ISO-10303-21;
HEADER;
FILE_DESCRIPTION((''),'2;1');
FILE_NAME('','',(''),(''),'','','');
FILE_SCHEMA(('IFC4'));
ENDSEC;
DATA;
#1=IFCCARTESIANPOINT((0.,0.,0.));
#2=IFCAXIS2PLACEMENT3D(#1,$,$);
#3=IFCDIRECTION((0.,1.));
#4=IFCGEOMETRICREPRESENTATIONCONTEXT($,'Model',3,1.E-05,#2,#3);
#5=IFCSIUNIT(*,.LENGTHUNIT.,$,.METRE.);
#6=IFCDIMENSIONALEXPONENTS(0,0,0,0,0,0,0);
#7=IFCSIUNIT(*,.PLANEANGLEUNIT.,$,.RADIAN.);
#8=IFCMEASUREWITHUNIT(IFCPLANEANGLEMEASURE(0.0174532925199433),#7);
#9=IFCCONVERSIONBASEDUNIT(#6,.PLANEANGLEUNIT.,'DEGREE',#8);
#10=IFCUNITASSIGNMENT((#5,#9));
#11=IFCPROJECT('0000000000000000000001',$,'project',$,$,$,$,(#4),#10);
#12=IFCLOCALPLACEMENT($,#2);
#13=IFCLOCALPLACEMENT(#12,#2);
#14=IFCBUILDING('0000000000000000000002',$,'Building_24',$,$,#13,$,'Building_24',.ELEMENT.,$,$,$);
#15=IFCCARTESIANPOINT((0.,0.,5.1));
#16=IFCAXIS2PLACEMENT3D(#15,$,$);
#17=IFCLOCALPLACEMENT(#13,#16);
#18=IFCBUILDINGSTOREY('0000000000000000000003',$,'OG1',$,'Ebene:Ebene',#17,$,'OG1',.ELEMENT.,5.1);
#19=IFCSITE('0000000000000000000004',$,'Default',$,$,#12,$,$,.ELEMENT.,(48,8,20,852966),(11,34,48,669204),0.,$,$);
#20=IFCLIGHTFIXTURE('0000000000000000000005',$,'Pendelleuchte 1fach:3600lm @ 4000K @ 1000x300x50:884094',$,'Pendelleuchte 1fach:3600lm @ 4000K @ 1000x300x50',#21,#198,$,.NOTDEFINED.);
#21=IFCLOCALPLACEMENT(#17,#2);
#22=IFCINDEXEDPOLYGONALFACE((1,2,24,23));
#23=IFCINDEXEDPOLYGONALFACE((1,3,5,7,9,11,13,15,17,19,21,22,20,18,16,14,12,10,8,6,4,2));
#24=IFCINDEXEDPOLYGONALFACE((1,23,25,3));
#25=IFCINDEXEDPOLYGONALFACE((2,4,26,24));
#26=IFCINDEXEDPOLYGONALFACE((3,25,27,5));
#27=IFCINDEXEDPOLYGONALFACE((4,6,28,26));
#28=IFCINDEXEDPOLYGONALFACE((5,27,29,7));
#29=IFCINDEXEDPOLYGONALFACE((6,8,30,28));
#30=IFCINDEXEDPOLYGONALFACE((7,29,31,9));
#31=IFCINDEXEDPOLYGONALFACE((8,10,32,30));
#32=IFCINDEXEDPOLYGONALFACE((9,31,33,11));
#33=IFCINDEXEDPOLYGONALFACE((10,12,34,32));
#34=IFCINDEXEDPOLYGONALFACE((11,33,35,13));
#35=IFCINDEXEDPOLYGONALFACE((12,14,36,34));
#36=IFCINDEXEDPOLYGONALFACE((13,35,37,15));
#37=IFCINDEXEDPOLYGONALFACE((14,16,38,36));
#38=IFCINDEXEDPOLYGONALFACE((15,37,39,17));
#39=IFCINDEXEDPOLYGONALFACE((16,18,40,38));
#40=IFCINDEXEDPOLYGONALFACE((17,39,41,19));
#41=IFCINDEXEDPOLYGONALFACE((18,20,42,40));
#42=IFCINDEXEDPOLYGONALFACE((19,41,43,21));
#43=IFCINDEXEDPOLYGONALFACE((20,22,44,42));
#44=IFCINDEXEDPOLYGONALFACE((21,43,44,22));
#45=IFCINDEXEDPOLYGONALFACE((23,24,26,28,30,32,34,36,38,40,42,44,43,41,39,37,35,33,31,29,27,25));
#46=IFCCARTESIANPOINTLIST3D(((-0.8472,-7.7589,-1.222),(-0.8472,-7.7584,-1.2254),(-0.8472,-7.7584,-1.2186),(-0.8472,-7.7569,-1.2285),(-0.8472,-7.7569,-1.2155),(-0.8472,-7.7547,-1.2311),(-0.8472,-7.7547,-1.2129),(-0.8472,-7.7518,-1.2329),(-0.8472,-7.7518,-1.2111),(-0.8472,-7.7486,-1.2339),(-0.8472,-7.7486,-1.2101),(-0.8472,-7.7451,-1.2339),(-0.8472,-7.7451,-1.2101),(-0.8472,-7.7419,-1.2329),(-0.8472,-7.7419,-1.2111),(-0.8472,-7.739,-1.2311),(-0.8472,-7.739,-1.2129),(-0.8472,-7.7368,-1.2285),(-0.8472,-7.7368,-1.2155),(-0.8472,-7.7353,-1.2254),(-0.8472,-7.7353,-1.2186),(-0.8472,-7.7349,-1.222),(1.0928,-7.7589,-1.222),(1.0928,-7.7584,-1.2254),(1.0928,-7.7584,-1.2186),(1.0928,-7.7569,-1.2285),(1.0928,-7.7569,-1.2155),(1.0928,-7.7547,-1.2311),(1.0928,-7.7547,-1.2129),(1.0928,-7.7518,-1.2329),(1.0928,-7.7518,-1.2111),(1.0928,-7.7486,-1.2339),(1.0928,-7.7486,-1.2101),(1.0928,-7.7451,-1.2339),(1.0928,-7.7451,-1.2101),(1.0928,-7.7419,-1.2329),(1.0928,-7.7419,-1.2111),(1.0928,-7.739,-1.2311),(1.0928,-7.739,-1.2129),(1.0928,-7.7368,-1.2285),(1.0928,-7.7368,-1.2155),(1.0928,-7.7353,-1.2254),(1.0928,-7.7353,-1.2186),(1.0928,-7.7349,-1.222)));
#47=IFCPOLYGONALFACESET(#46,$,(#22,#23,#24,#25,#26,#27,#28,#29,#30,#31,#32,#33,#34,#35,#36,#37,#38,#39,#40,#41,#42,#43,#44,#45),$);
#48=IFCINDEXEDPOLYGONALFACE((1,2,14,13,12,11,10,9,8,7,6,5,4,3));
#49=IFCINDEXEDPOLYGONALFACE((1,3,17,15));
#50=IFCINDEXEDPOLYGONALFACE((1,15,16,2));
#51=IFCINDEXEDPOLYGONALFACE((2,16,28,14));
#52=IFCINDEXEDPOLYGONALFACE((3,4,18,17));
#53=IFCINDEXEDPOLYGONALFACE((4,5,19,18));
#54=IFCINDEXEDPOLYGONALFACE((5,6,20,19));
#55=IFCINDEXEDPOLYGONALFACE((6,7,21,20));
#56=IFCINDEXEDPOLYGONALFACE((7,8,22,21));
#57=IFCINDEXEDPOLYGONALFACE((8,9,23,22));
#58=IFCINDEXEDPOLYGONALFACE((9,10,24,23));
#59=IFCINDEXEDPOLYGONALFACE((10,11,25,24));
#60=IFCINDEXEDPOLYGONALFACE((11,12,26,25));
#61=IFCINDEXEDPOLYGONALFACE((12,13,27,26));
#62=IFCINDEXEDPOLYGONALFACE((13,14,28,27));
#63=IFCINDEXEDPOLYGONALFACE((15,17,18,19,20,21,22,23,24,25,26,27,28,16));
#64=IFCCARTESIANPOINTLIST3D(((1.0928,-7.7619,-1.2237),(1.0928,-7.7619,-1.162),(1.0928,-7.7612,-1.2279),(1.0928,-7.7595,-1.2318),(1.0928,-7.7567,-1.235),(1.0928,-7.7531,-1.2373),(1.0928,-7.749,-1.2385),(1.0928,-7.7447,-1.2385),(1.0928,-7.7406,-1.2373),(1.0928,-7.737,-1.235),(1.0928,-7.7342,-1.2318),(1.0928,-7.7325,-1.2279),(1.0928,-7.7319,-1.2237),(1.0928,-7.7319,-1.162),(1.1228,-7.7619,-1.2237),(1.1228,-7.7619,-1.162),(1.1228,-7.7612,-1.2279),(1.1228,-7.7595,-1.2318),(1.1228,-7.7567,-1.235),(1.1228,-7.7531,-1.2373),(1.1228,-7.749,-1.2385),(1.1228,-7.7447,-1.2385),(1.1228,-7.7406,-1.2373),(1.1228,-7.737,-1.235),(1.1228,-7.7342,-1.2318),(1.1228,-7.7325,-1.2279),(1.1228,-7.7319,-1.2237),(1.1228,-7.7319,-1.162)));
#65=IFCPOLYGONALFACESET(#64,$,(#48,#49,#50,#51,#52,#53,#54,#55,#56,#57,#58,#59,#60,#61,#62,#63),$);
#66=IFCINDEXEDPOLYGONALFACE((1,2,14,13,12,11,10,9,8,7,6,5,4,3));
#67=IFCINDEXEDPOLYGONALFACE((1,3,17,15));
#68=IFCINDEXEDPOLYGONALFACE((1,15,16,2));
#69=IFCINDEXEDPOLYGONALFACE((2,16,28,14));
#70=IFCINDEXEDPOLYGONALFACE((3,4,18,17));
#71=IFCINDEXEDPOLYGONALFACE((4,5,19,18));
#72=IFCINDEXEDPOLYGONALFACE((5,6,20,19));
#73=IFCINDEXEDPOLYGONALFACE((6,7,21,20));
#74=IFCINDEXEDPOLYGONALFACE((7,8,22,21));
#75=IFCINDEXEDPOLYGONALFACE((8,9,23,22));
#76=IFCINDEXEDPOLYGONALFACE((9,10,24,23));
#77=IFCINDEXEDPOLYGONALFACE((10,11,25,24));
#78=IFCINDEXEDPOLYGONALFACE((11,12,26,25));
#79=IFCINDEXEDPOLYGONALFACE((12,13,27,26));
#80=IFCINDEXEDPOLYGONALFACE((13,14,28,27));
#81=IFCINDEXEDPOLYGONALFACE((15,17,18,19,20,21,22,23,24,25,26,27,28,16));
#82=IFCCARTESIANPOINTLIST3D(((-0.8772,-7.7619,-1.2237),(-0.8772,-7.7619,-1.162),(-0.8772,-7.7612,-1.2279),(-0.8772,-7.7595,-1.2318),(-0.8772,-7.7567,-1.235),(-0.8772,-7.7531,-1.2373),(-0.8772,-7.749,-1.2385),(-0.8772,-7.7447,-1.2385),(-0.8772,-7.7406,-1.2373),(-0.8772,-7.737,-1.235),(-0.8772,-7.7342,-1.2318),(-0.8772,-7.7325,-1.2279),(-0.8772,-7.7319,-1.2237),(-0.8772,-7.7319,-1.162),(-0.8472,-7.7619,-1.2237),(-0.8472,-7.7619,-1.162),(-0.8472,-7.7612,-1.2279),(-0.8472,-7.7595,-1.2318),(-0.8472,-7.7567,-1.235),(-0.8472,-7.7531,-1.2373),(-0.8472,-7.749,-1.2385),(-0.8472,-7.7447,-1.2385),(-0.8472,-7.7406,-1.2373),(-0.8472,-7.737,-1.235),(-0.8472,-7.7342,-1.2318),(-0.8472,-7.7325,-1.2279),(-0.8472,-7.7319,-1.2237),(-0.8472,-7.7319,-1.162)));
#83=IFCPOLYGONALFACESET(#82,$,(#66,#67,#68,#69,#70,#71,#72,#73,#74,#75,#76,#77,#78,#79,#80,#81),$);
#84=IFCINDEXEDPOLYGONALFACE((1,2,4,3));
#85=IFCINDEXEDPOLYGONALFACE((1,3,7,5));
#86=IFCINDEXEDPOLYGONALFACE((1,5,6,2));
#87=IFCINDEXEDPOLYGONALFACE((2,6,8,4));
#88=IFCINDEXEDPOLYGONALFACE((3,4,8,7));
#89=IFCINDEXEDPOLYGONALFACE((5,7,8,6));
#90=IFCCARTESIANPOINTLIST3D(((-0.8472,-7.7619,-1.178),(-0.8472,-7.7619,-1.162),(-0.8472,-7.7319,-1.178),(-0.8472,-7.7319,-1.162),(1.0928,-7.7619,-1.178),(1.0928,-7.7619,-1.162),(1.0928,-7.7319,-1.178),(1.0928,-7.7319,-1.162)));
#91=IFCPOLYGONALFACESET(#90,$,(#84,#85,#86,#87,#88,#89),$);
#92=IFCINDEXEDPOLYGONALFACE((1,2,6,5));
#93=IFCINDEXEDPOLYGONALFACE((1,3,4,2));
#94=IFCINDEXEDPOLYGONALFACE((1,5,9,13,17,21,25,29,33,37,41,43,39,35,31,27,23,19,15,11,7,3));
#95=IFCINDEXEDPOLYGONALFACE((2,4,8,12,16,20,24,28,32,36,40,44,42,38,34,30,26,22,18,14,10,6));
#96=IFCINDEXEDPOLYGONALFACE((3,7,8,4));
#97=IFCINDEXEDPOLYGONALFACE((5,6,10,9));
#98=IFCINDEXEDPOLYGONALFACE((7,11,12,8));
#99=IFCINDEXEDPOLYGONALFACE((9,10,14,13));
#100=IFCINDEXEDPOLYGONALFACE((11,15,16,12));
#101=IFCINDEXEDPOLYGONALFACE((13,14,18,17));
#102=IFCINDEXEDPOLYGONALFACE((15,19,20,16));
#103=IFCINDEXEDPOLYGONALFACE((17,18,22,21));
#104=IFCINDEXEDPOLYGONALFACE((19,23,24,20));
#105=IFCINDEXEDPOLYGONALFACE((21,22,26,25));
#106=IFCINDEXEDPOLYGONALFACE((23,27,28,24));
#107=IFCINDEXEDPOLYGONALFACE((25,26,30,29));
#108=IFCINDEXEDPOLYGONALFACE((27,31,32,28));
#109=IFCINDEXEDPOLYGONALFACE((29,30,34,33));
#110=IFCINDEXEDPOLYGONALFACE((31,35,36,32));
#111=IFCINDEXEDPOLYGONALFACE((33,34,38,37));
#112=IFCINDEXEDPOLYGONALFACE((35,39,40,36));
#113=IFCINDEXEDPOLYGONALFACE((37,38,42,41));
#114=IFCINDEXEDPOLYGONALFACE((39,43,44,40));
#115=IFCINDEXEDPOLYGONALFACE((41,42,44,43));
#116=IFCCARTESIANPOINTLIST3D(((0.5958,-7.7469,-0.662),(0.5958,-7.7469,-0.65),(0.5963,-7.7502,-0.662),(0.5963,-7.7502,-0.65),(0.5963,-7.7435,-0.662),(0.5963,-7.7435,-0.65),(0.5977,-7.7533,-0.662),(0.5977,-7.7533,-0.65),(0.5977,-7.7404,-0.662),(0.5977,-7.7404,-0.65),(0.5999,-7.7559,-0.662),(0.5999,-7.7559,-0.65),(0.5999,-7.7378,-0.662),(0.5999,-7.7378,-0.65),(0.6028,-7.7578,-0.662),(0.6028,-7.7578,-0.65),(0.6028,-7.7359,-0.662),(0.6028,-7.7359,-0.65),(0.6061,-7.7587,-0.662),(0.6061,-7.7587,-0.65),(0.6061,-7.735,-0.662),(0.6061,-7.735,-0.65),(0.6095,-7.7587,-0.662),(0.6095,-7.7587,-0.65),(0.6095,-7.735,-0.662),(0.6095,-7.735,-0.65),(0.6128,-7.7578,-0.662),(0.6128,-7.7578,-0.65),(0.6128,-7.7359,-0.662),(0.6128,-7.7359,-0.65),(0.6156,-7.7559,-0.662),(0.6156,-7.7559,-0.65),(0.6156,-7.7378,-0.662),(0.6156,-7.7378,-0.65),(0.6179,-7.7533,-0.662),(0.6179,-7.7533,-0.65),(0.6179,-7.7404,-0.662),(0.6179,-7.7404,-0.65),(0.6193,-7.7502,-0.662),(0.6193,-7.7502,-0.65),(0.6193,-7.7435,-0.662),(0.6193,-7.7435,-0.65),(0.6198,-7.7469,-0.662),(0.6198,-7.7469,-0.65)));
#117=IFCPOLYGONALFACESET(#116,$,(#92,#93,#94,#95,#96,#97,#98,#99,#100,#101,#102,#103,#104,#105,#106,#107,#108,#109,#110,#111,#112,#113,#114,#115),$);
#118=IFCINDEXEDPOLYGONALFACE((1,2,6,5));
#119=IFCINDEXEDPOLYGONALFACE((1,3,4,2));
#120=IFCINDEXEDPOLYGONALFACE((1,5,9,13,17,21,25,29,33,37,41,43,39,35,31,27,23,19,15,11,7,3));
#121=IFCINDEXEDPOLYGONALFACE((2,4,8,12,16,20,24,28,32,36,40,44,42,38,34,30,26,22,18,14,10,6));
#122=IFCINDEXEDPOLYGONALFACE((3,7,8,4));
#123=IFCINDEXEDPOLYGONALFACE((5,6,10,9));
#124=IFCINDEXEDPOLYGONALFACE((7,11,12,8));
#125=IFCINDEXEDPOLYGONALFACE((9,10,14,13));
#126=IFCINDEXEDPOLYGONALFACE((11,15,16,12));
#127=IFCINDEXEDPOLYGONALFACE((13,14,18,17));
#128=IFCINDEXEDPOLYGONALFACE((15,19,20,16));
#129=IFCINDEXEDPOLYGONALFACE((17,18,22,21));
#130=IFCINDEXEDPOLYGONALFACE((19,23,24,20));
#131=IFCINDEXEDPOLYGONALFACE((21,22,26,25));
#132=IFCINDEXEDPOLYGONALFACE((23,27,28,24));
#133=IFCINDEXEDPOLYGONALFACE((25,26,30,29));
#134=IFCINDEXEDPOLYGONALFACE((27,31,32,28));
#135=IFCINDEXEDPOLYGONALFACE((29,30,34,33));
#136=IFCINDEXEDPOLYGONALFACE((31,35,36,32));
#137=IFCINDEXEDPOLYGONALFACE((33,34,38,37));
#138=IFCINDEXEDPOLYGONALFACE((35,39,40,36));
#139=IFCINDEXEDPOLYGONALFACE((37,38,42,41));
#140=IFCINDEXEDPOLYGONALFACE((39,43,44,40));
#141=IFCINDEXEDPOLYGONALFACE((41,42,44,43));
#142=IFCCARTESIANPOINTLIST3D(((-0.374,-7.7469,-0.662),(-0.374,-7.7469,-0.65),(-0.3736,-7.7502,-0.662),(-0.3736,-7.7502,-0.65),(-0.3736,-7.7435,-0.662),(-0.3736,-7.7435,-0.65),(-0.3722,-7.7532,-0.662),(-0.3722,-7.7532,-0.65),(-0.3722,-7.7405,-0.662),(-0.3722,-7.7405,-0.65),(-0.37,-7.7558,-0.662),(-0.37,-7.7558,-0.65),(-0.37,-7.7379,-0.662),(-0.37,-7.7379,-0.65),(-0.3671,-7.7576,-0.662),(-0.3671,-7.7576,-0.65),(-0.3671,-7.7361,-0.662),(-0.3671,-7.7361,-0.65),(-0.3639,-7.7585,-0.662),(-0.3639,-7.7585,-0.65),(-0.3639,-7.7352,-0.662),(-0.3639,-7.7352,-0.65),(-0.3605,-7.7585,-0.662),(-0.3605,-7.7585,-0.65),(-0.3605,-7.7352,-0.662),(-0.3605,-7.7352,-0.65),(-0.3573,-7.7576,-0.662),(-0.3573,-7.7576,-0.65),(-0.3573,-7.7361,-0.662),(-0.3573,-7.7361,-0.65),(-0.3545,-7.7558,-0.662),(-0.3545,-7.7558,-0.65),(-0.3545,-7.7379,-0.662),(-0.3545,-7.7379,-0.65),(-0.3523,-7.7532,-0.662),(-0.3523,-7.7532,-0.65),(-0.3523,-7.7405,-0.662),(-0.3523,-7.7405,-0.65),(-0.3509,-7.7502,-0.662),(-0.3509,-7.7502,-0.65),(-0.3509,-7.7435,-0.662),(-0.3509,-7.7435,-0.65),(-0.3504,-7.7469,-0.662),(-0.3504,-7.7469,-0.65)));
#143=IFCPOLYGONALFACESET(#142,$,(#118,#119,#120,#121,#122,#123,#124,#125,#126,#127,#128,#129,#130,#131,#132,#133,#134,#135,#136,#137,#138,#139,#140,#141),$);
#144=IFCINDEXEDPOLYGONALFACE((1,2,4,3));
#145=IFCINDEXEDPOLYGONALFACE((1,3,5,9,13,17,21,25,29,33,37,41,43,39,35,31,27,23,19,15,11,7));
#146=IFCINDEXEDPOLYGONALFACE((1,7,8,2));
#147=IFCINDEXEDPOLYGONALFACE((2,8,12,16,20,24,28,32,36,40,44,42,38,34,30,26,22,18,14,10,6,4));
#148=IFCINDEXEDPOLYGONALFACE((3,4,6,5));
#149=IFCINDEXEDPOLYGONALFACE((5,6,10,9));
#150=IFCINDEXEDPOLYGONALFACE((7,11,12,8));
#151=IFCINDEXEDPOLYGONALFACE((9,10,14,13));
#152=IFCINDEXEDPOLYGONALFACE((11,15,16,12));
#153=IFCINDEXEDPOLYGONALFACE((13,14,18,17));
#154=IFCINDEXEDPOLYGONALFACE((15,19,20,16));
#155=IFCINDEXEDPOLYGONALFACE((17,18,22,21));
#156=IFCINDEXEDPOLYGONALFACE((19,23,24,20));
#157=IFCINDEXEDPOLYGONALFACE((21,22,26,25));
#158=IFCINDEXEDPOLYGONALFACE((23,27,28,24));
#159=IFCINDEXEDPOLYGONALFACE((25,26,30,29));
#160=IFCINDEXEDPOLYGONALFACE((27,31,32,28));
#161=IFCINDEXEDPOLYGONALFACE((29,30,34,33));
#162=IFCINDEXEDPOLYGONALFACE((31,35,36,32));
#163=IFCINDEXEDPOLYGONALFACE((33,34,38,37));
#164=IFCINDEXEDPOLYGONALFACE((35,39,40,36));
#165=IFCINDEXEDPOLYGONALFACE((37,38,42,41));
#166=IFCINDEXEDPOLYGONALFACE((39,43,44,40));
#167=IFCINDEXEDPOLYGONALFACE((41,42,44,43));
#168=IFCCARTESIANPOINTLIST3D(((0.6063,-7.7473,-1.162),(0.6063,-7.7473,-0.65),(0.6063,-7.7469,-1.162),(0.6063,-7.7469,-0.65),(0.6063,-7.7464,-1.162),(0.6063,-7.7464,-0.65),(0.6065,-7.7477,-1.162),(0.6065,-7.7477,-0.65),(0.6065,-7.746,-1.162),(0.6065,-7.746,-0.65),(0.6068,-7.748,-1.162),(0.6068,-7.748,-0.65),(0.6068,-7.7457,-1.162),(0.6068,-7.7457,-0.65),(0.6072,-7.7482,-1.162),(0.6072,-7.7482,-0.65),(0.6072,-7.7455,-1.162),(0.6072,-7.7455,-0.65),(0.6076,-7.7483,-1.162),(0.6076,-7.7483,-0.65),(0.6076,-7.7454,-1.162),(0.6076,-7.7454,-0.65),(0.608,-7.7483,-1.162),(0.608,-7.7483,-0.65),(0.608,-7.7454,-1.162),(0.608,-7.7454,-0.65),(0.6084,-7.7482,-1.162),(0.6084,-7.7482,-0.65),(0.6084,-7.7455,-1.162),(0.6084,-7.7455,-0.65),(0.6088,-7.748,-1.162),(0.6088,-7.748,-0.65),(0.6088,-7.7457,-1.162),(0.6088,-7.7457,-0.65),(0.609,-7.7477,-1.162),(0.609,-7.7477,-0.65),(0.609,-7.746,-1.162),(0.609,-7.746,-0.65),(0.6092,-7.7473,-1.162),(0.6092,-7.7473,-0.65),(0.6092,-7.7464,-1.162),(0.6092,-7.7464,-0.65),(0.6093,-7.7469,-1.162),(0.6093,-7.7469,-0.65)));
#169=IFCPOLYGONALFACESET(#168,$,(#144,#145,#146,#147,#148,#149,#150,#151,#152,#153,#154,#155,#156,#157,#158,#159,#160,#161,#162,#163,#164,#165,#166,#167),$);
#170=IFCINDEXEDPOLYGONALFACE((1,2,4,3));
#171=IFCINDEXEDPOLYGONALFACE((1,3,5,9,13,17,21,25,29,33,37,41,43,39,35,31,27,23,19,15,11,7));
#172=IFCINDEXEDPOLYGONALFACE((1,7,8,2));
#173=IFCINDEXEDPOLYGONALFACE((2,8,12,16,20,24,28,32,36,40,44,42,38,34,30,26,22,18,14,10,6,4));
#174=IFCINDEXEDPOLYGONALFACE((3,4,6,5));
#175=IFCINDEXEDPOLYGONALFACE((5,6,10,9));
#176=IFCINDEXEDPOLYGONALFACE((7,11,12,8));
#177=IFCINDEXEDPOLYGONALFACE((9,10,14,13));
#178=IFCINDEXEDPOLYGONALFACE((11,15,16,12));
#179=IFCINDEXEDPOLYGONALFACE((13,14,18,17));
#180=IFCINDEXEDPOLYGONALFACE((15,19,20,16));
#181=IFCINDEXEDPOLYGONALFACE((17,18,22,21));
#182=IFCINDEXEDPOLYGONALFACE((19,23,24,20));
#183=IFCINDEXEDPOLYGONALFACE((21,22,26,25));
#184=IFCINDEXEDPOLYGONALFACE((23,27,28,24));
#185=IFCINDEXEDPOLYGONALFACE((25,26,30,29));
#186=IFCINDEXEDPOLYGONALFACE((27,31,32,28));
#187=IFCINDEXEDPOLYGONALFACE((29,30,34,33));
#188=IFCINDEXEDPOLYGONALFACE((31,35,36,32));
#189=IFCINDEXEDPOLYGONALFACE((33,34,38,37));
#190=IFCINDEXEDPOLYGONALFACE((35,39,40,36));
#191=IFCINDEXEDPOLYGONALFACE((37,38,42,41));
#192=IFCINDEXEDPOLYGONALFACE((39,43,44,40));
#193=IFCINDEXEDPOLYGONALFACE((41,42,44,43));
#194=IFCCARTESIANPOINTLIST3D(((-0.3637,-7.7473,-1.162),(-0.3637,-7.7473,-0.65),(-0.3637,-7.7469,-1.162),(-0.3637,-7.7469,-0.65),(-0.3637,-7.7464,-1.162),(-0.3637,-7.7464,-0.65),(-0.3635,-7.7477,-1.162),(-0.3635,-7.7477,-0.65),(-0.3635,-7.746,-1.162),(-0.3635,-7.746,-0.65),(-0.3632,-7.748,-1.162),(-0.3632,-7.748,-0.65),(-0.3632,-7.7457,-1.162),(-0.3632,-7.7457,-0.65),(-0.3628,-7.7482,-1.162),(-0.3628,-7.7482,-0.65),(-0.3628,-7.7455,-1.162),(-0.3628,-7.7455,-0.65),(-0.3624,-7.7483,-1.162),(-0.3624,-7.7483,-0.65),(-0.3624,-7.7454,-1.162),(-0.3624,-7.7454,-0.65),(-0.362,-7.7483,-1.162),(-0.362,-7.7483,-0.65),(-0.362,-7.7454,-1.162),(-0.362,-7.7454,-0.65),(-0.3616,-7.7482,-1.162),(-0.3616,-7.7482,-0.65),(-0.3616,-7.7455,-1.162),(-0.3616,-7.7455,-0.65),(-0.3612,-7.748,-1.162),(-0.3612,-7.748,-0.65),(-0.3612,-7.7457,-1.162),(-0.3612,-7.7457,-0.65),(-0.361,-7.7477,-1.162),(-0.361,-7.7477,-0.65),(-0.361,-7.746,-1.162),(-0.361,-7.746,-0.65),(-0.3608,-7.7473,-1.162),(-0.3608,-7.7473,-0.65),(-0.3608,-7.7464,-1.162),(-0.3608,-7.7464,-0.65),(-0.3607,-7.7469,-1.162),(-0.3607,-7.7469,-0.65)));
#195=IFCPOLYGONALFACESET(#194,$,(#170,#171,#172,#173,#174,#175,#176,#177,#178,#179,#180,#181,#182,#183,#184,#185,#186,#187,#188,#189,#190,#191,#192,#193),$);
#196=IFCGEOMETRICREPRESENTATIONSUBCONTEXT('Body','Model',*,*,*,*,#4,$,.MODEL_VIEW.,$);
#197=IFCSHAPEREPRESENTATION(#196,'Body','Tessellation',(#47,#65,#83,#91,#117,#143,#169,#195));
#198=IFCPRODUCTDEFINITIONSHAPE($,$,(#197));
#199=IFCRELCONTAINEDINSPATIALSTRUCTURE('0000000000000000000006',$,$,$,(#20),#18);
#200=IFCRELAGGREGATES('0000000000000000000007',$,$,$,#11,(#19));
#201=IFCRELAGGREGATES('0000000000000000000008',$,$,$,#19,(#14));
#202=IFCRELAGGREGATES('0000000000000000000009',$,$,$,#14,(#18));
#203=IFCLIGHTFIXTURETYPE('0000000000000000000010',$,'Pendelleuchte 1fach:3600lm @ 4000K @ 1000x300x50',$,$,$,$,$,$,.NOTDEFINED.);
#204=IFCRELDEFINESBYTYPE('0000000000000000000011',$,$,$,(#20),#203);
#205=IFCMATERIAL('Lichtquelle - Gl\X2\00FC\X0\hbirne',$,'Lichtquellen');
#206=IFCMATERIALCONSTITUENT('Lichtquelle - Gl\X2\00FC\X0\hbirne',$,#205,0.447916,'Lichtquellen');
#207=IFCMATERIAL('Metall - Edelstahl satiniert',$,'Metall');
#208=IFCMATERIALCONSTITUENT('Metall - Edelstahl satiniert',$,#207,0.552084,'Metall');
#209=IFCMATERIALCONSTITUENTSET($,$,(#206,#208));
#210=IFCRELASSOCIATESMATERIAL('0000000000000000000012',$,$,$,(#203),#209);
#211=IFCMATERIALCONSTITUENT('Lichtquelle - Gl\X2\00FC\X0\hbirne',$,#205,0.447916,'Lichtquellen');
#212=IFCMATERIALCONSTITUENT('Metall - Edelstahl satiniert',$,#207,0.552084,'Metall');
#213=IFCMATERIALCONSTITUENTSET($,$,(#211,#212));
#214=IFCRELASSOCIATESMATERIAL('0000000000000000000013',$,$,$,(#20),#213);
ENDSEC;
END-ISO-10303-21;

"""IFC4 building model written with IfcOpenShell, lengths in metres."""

from ifc_helpers import new_model, entity, si_unit, converted_unit, direction, frame, origin, place, context, subcontext, project, spatial, line, arc, indexed_curve, outline, extrude, source, transform, mapped, material, constituent, constituent_set, type_object, type_shapes, element, save


model = new_model("IFC4")

# Units and contexts
model_context = context("Model", 3, precision=1e-05, world=origin(), true_north=direction((0.0, 1.0)))
body_context = subcontext(model_context, "Body", "Model", "MODEL_VIEW")
ifc_project = project(units=[si_unit("LENGTHUNIT", "METRE"), converted_unit("PLANEANGLEUNIT", "DEGREE", entity("IfcPlaneAngleMeasure", 0.0174532925199433), si_unit("PLANEANGLEUNIT", "RADIAN"), dimensions=[0, 0, 0, 0, 0, 0, 0])], contexts=[model_context])

# Site, building, storey
site_placement = place(None, origin())
site = spatial("IfcSite", under=ifc_project, at=site_placement, Name="Default", CompositionType="ELEMENT", RefLatitude=(48, 8, 20, 852966), RefLongitude=(11, 34, 48, 669204), RefElevation=0.0)
building_placement = place(site_placement, origin())
building = spatial("IfcBuilding", under=site, at=building_placement, Name="Building_24", LongName="Building_24", CompositionType="ELEMENT")
storey_placement = place(building_placement, frame((0.0, 0.0, 5.1)))
storey = spatial("IfcBuildingStorey", under=building, at=storey_placement, Name="OG1", ObjectType="Ebene:Ebene", LongName="OG1", CompositionType="ELEMENT", Elevation=5.1)

# Light fixture
ifc_material_1 = material(Name="Lichtquelle - Glühbirne", Category="Lichtquellen")
ifc_material_2 = material(Name="Metall - Edelstahl satiniert", Category="Metall")
ifc_constituent_1 = constituent(ifc_material_1, Name="Lichtquelle - Glühbirne", Category="Lichtquellen", fraction=0.447916)
ifc_constituent_2 = constituent(ifc_material_2, Name="Metall - Edelstahl satiniert", Category="Metall", fraction=0.552084)
ifc_constituent_set_1 = constituent_set(constituents=[ifc_constituent_1, ifc_constituent_2])
light_fixture_type_1 = type_object("IfcLightFixtureType", Name="Pendelleuchte 1fach:3600lm @ 4000K @ 1000x300x50", PredefinedType="NOTDEFINED", material=ifc_constituent_set_1)
shared_shape_1 = source(origin(), body_context, "Body", "SweptSolid", [
    extrude(outline(indexed_curve([(-0.012, 0.0), (0.0, -0.012), (0.012, 0.0), (0.0, 0.012)], segments=[arc(1, 2, 3), arc(3, 4, 1)], self_intersect=False)), frame((-0.97, 0.0, -0.572), z_axis=(1.0, 0.0, 0.0), x_axis=(0.0, 1.0, 0.0)), (0.0, 0.0, 1.0), 1.94),
    extrude(outline(indexed_curve([(-0.0308, -0.015), (0.0308, -0.015), (0.0308, 0.015), (-0.0308, 0.015), (-0.0458, 0.0)], segments=[line(1, 2, 3, 4), arc(4, 5, 1)], self_intersect=False)), frame((0.97, 0.0, -0.5428), z_axis=(1.0, 0.0, 0.0), x_axis=(0.0, 0.0, 1.0)), (0.0, 0.0, 1.0), 0.03),
    extrude(outline(indexed_curve([(-0.0308, -0.015), (0.0308, -0.015), (0.0308, 0.015), (-0.0308, 0.015), (-0.0458, 0.0)], segments=[line(1, 2, 3, 4), arc(4, 5, 1)], self_intersect=False)), frame((-1.0, 0.0, -0.5428), z_axis=(1.0, 0.0, 0.0), x_axis=(0.0, 0.0, 1.0)), (0.0, 0.0, 1.0), 0.03),
    extrude(outline(indexed_curve([(-0.97, -0.015), (0.97, -0.015), (0.97, 0.015), (-0.97, 0.015), (-0.97, -0.015)], self_intersect=False)), frame((0.0, 0.0, -0.528), z_axis=(0.0, 0.0, 1.0), x_axis=(-1.0, 0.0, 0.0)), (0.0, 0.0, 1.0), 0.016),
    extrude(outline(indexed_curve([(-0.012, 0.0), (0.0, -0.012), (0.012, 0.0), (0.0, 0.012)], segments=[arc(1, 2, 3), arc(3, 4, 1)], self_intersect=False)), frame((0.485, 0.0, -0.012)), (0.0, 0.0, 1.0), 0.012),
    extrude(outline(indexed_curve([(-0.0118, 0.0), (0.0, -0.0118), (0.0118, 0.0), (0.0, 0.0118)], segments=[arc(1, 2, 3), arc(3, 4, 1)], self_intersect=False)), frame((-0.485, 0.0, -0.012)), (0.0, 0.0, 1.0), 0.012),
    extrude(outline(indexed_curve([(-0.0015, 0.0), (0.0, -0.0015), (0.0015, 0.0), (0.0, 0.0015)], segments=[arc(1, 2, 3), arc(3, 4, 1)], self_intersect=False)), frame((0.485, 0.0, -0.512)), (0.0, 0.0, 1.0), 0.512),
    extrude(outline(indexed_curve([(-0.0015, 0.0), (0.0, -0.0015), (0.0015, 0.0), (0.0, 0.0015)], segments=[arc(1, 2, 3), arc(3, 4, 1)], self_intersect=False)), frame((-0.485, 0.0, -0.512)), (0.0, 0.0, 1.0), 0.512),
])
type_shapes(light_fixture_type_1, [shared_shape_1])
ifc_constituent_3 = constituent(ifc_material_1, Name="Lichtquelle - Glühbirne", Category="Lichtquellen", fraction=0.447916)
ifc_constituent_4 = constituent(ifc_material_2, Name="Metall - Edelstahl satiniert", Category="Metall", fraction=0.552084)
ifc_constituent_set_2 = constituent_set(constituents=[ifc_constituent_3, ifc_constituent_4])
light_fixture_1_placement = place(storey_placement, frame((0.1228, -7.7469, -0.65)))
element("IfcLightFixture", 1, at=light_fixture_1_placement, inside=storey, type_object=light_fixture_type_1, material=ifc_constituent_set_2, Name="Pendelleuchte 1fach:3600lm @ 4000K @ 1000x300x50:884094", ObjectType="Pendelleuchte 1fach:3600lm @ 4000K @ 1000x300x50", PredefinedType="NOTDEFINED", context=body_context, shape_type="MappedRepresentation", body=[
    mapped(shared_shape_1, transform((0.0, 0.0, 0.0), scale=1.0)),
])

save(model, "model.ifc")
